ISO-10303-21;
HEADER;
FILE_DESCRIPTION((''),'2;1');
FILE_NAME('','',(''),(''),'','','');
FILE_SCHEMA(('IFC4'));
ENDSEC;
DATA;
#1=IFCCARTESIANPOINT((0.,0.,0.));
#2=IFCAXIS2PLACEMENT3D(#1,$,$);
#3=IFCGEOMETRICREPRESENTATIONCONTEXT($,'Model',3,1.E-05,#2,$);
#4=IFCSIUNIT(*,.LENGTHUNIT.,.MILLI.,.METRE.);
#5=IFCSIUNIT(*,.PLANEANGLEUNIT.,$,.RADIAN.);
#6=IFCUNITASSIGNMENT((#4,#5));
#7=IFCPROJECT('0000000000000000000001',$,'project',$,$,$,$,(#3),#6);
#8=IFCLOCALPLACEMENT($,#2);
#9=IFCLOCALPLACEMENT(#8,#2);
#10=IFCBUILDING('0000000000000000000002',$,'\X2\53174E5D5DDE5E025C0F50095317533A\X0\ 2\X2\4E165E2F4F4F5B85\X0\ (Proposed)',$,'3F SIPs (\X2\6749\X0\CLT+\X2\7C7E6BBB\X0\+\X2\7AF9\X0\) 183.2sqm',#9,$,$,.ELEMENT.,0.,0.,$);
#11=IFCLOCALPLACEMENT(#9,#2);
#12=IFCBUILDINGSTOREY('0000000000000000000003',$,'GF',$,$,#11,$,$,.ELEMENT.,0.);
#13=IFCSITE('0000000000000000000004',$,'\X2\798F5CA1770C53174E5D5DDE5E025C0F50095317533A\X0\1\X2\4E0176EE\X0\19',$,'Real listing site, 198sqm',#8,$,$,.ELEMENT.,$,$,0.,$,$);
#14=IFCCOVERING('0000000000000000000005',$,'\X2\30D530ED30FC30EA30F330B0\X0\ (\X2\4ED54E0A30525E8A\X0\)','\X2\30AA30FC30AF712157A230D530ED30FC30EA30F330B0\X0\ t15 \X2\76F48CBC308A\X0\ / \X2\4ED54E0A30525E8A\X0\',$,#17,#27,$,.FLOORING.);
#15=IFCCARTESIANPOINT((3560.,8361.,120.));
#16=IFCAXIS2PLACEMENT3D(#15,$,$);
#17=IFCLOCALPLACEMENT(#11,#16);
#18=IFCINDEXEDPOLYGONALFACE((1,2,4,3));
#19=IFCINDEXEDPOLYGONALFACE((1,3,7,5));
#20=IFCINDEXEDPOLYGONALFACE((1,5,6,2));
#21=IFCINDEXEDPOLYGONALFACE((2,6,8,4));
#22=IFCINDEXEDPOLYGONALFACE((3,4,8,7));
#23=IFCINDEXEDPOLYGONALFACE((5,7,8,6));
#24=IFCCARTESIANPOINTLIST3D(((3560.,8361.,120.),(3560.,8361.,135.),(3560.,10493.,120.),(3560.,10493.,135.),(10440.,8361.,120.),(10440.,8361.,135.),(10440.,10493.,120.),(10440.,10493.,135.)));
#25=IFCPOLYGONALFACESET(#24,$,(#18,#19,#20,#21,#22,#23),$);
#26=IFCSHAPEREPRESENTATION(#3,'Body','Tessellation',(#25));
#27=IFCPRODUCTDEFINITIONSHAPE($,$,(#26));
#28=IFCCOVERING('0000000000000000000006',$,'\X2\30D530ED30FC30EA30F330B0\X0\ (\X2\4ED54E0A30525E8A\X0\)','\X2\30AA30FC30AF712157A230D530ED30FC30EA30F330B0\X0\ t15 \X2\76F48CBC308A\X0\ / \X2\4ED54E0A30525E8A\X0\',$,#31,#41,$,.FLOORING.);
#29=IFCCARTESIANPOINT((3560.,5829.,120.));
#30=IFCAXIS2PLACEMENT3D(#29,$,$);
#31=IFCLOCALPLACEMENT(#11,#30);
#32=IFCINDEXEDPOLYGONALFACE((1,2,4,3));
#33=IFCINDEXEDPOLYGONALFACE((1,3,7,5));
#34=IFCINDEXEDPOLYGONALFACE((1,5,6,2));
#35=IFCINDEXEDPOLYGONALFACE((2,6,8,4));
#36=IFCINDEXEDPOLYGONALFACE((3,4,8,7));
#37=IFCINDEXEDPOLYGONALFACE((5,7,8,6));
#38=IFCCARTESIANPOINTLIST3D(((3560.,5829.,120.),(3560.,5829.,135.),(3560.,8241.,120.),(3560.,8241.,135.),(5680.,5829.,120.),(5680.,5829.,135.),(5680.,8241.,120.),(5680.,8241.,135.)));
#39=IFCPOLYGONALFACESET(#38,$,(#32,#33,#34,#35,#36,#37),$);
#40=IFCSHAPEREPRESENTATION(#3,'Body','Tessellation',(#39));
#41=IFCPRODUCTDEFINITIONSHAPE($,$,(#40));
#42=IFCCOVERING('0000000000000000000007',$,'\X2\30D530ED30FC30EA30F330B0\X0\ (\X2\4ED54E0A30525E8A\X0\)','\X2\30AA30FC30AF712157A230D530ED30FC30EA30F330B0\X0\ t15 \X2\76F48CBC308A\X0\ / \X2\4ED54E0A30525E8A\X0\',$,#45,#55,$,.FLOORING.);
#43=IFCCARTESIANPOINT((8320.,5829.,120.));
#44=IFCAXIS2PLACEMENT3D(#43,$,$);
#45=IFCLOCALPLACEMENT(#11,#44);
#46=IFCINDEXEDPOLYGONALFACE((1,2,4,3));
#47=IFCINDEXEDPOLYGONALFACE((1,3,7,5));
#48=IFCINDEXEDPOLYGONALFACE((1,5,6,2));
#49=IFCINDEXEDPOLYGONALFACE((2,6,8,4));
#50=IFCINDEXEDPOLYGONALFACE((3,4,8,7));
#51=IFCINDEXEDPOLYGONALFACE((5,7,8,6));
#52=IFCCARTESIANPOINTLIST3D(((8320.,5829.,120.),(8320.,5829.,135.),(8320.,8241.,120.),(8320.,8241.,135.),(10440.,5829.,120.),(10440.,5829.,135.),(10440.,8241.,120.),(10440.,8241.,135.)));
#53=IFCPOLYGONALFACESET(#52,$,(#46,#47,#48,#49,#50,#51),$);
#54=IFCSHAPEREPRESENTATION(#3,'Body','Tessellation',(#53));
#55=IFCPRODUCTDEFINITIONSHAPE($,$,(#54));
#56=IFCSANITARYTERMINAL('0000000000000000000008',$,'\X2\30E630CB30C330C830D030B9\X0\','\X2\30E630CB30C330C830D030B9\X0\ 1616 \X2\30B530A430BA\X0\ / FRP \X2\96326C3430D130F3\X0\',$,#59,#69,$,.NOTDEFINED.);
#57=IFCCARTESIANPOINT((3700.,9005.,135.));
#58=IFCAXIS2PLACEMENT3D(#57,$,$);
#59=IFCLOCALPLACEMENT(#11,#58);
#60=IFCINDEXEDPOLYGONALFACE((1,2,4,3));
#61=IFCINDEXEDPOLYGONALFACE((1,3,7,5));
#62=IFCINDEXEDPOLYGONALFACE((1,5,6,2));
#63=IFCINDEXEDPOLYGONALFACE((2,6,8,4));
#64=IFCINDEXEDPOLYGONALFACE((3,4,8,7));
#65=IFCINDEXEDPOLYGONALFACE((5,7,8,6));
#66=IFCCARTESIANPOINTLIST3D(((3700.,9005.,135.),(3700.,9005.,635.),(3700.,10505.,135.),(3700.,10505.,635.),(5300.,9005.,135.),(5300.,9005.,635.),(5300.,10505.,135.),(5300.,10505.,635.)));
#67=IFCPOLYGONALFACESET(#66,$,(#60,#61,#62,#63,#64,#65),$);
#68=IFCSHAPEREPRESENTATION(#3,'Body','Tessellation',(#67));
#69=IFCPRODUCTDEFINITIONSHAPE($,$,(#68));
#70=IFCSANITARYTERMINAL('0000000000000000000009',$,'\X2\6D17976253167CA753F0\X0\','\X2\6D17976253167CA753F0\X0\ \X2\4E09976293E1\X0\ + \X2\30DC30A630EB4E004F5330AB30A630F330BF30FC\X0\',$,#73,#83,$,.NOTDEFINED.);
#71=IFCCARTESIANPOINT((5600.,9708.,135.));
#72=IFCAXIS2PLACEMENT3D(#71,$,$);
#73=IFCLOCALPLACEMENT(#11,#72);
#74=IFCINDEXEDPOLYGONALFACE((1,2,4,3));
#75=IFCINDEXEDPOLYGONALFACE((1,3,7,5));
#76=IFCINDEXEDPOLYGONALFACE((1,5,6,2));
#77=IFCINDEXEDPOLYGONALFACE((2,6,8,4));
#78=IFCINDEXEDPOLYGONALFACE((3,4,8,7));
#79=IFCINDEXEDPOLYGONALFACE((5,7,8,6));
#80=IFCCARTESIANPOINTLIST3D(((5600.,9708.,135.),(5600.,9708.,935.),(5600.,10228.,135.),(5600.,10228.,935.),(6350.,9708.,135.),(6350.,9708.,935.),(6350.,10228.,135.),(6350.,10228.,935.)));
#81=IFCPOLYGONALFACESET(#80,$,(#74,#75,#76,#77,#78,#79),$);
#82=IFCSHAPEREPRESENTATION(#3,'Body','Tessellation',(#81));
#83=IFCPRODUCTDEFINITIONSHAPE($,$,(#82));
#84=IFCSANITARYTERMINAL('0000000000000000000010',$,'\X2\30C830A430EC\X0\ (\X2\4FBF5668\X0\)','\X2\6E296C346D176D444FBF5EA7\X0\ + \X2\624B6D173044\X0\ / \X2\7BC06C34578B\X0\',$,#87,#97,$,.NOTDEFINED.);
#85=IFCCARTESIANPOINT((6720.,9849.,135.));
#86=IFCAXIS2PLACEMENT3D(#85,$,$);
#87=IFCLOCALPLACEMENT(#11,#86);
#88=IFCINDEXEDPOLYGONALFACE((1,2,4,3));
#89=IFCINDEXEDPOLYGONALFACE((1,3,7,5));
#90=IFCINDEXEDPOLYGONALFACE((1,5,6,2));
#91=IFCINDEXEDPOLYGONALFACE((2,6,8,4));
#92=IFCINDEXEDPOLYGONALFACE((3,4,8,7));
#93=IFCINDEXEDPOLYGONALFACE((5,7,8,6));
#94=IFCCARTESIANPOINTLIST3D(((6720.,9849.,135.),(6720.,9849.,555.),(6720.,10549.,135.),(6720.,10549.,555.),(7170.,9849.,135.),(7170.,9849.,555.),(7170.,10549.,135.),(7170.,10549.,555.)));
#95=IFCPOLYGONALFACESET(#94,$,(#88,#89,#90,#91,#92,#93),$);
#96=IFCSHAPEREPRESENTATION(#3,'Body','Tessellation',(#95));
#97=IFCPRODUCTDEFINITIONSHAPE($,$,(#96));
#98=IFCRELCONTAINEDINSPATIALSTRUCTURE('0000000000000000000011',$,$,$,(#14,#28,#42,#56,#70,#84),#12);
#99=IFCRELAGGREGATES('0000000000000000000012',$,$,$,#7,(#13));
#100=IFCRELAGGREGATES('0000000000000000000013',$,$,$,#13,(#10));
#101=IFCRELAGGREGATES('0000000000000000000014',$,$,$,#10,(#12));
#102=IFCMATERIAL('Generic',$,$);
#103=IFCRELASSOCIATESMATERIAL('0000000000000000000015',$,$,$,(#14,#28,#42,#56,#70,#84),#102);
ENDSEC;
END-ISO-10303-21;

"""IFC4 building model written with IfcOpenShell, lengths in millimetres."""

from ifc_helpers import new_model, si_unit, frame, frame_2d, origin, place, context, project, spatial, rectangle, extrude, material, element, save


model = new_model("IFC4")

# Units and contexts
model_context = context("Model", 3, precision=1e-05, world=origin())
ifc_project = project(units=[si_unit("LENGTHUNIT", "METRE", prefix="MILLI"), si_unit("PLANEANGLEUNIT", "RADIAN")], contexts=[model_context])

# Site, building, storey
site_placement = place(None, origin())
site = spatial("IfcSite", under=ifc_project, at=site_placement, Name="福岡県北九州市小倉北区1丁目19", ObjectType="Real listing site, 198sqm", CompositionType="ELEMENT", RefElevation=0.0)
building_placement = place(site_placement, origin())
building = spatial("IfcBuilding", under=site, at=building_placement, Name="北九州市小倉北区 2世帯住宅 (Proposed)", ObjectType="3F SIPs (杉CLT+籾殻+竹) 183.2sqm", CompositionType="ELEMENT", ElevationOfRefHeight=0.0, ElevationOfTerrain=0.0)
storey_placement = place(building_placement, origin())
storey = spatial("IfcBuildingStorey", under=building, at=storey_placement, Name="GF", CompositionType="ELEMENT", Elevation=0.0)

# Coverings
ifc_material_1 = material(Name="Generic")
covering_1_placement = place(storey_placement, frame((3560.0, 8361.0, 120.0)))
element("IfcCovering", 1, at=covering_1_placement, inside=storey, material=ifc_material_1, Name="フローリング (仕上げ床)", Description="オーク無垢フローリング t15 直貼り / 仕上げ床", PredefinedType="FLOORING", context=model_context, shape_type="SweptSolid", body=[
    extrude(rectangle(XDim=6880.0, YDim=2132.0, at=frame_2d((3440.0, 1066.0))), frame((3560.0, 8361.0, 120.0)), (0.0, 0.0, 1.0), 15.0),
])
covering_2_placement = place(storey_placement, frame((3560.0, 5829.0, 120.0)))
element("IfcCovering", 2, at=covering_2_placement, inside=storey, material=ifc_material_1, Name="フローリング (仕上げ床)", Description="オーク無垢フローリング t15 直貼り / 仕上げ床", PredefinedType="FLOORING", context=model_context, shape_type="SweptSolid", body=[
    extrude(rectangle(XDim=2120.0, YDim=2412.0, at=frame_2d((1060.0, 1206.0))), frame((3560.0, 5829.0, 120.0)), (0.0, 0.0, 1.0), 15.0),
])
covering_3_placement = place(storey_placement, frame((8320.0, 5829.0, 120.0)))
element("IfcCovering", 3, at=covering_3_placement, inside=storey, material=ifc_material_1, Name="フローリング (仕上げ床)", Description="オーク無垢フローリング t15 直貼り / 仕上げ床", PredefinedType="FLOORING", context=model_context, shape_type="SweptSolid", body=[
    extrude(rectangle(XDim=2120.0, YDim=2412.0, at=frame_2d((1060.0, 1206.0))), frame((8320.0, 5829.0, 120.0)), (0.0, 0.0, 1.0), 15.0),
])

# Sanitary terminals
sanitary_terminal_1_placement = place(storey_placement, frame((3700.0, 9005.0, 135.0)))
element("IfcSanitaryTerminal", 4, at=sanitary_terminal_1_placement, inside=storey, material=ifc_material_1, Name="ユニットバス", Description="ユニットバス 1616 サイズ / FRP 防水パン", PredefinedType="NOTDEFINED", context=model_context, shape_type="SweptSolid", body=[
    extrude(rectangle(XDim=1600.0, YDim=1500.0, at=frame_2d((800.0, 750.0))), frame((3700.0, 9005.0, 135.0)), (0.0, 0.0, 1.0), 500.0),
])
sanitary_terminal_2_placement = place(storey_placement, frame((5600.0, 9708.0, 135.0)))
element("IfcSanitaryTerminal", 5, at=sanitary_terminal_2_placement, inside=storey, material=ifc_material_1, Name="洗面化粧台", Description="洗面化粧台 三面鏡 + ボウル一体カウンター", PredefinedType="NOTDEFINED", context=model_context, shape_type="SweptSolid", body=[
    extrude(rectangle(XDim=750.0, YDim=520.0, at=frame_2d((375.0, 260.0))), frame((5600.0, 9708.0, 135.0)), (0.0, 0.0, 1.0), 800.0),
])
sanitary_terminal_3_placement = place(storey_placement, frame((6720.0, 9849.0, 135.0)))
element("IfcSanitaryTerminal", 6, at=sanitary_terminal_3_placement, inside=storey, material=ifc_material_1, Name="トイレ (便器)", Description="温水洗浄便座 + 手洗い / 節水型", PredefinedType="NOTDEFINED", context=model_context, shape_type="SweptSolid", body=[
    extrude(rectangle(XDim=450.0, YDim=700.0, at=frame_2d((225.0, 350.0))), frame((6720.0, 9849.0, 135.0)), (0.0, 0.0, 1.0), 420.0),
])

save(model, "model.ifc")
